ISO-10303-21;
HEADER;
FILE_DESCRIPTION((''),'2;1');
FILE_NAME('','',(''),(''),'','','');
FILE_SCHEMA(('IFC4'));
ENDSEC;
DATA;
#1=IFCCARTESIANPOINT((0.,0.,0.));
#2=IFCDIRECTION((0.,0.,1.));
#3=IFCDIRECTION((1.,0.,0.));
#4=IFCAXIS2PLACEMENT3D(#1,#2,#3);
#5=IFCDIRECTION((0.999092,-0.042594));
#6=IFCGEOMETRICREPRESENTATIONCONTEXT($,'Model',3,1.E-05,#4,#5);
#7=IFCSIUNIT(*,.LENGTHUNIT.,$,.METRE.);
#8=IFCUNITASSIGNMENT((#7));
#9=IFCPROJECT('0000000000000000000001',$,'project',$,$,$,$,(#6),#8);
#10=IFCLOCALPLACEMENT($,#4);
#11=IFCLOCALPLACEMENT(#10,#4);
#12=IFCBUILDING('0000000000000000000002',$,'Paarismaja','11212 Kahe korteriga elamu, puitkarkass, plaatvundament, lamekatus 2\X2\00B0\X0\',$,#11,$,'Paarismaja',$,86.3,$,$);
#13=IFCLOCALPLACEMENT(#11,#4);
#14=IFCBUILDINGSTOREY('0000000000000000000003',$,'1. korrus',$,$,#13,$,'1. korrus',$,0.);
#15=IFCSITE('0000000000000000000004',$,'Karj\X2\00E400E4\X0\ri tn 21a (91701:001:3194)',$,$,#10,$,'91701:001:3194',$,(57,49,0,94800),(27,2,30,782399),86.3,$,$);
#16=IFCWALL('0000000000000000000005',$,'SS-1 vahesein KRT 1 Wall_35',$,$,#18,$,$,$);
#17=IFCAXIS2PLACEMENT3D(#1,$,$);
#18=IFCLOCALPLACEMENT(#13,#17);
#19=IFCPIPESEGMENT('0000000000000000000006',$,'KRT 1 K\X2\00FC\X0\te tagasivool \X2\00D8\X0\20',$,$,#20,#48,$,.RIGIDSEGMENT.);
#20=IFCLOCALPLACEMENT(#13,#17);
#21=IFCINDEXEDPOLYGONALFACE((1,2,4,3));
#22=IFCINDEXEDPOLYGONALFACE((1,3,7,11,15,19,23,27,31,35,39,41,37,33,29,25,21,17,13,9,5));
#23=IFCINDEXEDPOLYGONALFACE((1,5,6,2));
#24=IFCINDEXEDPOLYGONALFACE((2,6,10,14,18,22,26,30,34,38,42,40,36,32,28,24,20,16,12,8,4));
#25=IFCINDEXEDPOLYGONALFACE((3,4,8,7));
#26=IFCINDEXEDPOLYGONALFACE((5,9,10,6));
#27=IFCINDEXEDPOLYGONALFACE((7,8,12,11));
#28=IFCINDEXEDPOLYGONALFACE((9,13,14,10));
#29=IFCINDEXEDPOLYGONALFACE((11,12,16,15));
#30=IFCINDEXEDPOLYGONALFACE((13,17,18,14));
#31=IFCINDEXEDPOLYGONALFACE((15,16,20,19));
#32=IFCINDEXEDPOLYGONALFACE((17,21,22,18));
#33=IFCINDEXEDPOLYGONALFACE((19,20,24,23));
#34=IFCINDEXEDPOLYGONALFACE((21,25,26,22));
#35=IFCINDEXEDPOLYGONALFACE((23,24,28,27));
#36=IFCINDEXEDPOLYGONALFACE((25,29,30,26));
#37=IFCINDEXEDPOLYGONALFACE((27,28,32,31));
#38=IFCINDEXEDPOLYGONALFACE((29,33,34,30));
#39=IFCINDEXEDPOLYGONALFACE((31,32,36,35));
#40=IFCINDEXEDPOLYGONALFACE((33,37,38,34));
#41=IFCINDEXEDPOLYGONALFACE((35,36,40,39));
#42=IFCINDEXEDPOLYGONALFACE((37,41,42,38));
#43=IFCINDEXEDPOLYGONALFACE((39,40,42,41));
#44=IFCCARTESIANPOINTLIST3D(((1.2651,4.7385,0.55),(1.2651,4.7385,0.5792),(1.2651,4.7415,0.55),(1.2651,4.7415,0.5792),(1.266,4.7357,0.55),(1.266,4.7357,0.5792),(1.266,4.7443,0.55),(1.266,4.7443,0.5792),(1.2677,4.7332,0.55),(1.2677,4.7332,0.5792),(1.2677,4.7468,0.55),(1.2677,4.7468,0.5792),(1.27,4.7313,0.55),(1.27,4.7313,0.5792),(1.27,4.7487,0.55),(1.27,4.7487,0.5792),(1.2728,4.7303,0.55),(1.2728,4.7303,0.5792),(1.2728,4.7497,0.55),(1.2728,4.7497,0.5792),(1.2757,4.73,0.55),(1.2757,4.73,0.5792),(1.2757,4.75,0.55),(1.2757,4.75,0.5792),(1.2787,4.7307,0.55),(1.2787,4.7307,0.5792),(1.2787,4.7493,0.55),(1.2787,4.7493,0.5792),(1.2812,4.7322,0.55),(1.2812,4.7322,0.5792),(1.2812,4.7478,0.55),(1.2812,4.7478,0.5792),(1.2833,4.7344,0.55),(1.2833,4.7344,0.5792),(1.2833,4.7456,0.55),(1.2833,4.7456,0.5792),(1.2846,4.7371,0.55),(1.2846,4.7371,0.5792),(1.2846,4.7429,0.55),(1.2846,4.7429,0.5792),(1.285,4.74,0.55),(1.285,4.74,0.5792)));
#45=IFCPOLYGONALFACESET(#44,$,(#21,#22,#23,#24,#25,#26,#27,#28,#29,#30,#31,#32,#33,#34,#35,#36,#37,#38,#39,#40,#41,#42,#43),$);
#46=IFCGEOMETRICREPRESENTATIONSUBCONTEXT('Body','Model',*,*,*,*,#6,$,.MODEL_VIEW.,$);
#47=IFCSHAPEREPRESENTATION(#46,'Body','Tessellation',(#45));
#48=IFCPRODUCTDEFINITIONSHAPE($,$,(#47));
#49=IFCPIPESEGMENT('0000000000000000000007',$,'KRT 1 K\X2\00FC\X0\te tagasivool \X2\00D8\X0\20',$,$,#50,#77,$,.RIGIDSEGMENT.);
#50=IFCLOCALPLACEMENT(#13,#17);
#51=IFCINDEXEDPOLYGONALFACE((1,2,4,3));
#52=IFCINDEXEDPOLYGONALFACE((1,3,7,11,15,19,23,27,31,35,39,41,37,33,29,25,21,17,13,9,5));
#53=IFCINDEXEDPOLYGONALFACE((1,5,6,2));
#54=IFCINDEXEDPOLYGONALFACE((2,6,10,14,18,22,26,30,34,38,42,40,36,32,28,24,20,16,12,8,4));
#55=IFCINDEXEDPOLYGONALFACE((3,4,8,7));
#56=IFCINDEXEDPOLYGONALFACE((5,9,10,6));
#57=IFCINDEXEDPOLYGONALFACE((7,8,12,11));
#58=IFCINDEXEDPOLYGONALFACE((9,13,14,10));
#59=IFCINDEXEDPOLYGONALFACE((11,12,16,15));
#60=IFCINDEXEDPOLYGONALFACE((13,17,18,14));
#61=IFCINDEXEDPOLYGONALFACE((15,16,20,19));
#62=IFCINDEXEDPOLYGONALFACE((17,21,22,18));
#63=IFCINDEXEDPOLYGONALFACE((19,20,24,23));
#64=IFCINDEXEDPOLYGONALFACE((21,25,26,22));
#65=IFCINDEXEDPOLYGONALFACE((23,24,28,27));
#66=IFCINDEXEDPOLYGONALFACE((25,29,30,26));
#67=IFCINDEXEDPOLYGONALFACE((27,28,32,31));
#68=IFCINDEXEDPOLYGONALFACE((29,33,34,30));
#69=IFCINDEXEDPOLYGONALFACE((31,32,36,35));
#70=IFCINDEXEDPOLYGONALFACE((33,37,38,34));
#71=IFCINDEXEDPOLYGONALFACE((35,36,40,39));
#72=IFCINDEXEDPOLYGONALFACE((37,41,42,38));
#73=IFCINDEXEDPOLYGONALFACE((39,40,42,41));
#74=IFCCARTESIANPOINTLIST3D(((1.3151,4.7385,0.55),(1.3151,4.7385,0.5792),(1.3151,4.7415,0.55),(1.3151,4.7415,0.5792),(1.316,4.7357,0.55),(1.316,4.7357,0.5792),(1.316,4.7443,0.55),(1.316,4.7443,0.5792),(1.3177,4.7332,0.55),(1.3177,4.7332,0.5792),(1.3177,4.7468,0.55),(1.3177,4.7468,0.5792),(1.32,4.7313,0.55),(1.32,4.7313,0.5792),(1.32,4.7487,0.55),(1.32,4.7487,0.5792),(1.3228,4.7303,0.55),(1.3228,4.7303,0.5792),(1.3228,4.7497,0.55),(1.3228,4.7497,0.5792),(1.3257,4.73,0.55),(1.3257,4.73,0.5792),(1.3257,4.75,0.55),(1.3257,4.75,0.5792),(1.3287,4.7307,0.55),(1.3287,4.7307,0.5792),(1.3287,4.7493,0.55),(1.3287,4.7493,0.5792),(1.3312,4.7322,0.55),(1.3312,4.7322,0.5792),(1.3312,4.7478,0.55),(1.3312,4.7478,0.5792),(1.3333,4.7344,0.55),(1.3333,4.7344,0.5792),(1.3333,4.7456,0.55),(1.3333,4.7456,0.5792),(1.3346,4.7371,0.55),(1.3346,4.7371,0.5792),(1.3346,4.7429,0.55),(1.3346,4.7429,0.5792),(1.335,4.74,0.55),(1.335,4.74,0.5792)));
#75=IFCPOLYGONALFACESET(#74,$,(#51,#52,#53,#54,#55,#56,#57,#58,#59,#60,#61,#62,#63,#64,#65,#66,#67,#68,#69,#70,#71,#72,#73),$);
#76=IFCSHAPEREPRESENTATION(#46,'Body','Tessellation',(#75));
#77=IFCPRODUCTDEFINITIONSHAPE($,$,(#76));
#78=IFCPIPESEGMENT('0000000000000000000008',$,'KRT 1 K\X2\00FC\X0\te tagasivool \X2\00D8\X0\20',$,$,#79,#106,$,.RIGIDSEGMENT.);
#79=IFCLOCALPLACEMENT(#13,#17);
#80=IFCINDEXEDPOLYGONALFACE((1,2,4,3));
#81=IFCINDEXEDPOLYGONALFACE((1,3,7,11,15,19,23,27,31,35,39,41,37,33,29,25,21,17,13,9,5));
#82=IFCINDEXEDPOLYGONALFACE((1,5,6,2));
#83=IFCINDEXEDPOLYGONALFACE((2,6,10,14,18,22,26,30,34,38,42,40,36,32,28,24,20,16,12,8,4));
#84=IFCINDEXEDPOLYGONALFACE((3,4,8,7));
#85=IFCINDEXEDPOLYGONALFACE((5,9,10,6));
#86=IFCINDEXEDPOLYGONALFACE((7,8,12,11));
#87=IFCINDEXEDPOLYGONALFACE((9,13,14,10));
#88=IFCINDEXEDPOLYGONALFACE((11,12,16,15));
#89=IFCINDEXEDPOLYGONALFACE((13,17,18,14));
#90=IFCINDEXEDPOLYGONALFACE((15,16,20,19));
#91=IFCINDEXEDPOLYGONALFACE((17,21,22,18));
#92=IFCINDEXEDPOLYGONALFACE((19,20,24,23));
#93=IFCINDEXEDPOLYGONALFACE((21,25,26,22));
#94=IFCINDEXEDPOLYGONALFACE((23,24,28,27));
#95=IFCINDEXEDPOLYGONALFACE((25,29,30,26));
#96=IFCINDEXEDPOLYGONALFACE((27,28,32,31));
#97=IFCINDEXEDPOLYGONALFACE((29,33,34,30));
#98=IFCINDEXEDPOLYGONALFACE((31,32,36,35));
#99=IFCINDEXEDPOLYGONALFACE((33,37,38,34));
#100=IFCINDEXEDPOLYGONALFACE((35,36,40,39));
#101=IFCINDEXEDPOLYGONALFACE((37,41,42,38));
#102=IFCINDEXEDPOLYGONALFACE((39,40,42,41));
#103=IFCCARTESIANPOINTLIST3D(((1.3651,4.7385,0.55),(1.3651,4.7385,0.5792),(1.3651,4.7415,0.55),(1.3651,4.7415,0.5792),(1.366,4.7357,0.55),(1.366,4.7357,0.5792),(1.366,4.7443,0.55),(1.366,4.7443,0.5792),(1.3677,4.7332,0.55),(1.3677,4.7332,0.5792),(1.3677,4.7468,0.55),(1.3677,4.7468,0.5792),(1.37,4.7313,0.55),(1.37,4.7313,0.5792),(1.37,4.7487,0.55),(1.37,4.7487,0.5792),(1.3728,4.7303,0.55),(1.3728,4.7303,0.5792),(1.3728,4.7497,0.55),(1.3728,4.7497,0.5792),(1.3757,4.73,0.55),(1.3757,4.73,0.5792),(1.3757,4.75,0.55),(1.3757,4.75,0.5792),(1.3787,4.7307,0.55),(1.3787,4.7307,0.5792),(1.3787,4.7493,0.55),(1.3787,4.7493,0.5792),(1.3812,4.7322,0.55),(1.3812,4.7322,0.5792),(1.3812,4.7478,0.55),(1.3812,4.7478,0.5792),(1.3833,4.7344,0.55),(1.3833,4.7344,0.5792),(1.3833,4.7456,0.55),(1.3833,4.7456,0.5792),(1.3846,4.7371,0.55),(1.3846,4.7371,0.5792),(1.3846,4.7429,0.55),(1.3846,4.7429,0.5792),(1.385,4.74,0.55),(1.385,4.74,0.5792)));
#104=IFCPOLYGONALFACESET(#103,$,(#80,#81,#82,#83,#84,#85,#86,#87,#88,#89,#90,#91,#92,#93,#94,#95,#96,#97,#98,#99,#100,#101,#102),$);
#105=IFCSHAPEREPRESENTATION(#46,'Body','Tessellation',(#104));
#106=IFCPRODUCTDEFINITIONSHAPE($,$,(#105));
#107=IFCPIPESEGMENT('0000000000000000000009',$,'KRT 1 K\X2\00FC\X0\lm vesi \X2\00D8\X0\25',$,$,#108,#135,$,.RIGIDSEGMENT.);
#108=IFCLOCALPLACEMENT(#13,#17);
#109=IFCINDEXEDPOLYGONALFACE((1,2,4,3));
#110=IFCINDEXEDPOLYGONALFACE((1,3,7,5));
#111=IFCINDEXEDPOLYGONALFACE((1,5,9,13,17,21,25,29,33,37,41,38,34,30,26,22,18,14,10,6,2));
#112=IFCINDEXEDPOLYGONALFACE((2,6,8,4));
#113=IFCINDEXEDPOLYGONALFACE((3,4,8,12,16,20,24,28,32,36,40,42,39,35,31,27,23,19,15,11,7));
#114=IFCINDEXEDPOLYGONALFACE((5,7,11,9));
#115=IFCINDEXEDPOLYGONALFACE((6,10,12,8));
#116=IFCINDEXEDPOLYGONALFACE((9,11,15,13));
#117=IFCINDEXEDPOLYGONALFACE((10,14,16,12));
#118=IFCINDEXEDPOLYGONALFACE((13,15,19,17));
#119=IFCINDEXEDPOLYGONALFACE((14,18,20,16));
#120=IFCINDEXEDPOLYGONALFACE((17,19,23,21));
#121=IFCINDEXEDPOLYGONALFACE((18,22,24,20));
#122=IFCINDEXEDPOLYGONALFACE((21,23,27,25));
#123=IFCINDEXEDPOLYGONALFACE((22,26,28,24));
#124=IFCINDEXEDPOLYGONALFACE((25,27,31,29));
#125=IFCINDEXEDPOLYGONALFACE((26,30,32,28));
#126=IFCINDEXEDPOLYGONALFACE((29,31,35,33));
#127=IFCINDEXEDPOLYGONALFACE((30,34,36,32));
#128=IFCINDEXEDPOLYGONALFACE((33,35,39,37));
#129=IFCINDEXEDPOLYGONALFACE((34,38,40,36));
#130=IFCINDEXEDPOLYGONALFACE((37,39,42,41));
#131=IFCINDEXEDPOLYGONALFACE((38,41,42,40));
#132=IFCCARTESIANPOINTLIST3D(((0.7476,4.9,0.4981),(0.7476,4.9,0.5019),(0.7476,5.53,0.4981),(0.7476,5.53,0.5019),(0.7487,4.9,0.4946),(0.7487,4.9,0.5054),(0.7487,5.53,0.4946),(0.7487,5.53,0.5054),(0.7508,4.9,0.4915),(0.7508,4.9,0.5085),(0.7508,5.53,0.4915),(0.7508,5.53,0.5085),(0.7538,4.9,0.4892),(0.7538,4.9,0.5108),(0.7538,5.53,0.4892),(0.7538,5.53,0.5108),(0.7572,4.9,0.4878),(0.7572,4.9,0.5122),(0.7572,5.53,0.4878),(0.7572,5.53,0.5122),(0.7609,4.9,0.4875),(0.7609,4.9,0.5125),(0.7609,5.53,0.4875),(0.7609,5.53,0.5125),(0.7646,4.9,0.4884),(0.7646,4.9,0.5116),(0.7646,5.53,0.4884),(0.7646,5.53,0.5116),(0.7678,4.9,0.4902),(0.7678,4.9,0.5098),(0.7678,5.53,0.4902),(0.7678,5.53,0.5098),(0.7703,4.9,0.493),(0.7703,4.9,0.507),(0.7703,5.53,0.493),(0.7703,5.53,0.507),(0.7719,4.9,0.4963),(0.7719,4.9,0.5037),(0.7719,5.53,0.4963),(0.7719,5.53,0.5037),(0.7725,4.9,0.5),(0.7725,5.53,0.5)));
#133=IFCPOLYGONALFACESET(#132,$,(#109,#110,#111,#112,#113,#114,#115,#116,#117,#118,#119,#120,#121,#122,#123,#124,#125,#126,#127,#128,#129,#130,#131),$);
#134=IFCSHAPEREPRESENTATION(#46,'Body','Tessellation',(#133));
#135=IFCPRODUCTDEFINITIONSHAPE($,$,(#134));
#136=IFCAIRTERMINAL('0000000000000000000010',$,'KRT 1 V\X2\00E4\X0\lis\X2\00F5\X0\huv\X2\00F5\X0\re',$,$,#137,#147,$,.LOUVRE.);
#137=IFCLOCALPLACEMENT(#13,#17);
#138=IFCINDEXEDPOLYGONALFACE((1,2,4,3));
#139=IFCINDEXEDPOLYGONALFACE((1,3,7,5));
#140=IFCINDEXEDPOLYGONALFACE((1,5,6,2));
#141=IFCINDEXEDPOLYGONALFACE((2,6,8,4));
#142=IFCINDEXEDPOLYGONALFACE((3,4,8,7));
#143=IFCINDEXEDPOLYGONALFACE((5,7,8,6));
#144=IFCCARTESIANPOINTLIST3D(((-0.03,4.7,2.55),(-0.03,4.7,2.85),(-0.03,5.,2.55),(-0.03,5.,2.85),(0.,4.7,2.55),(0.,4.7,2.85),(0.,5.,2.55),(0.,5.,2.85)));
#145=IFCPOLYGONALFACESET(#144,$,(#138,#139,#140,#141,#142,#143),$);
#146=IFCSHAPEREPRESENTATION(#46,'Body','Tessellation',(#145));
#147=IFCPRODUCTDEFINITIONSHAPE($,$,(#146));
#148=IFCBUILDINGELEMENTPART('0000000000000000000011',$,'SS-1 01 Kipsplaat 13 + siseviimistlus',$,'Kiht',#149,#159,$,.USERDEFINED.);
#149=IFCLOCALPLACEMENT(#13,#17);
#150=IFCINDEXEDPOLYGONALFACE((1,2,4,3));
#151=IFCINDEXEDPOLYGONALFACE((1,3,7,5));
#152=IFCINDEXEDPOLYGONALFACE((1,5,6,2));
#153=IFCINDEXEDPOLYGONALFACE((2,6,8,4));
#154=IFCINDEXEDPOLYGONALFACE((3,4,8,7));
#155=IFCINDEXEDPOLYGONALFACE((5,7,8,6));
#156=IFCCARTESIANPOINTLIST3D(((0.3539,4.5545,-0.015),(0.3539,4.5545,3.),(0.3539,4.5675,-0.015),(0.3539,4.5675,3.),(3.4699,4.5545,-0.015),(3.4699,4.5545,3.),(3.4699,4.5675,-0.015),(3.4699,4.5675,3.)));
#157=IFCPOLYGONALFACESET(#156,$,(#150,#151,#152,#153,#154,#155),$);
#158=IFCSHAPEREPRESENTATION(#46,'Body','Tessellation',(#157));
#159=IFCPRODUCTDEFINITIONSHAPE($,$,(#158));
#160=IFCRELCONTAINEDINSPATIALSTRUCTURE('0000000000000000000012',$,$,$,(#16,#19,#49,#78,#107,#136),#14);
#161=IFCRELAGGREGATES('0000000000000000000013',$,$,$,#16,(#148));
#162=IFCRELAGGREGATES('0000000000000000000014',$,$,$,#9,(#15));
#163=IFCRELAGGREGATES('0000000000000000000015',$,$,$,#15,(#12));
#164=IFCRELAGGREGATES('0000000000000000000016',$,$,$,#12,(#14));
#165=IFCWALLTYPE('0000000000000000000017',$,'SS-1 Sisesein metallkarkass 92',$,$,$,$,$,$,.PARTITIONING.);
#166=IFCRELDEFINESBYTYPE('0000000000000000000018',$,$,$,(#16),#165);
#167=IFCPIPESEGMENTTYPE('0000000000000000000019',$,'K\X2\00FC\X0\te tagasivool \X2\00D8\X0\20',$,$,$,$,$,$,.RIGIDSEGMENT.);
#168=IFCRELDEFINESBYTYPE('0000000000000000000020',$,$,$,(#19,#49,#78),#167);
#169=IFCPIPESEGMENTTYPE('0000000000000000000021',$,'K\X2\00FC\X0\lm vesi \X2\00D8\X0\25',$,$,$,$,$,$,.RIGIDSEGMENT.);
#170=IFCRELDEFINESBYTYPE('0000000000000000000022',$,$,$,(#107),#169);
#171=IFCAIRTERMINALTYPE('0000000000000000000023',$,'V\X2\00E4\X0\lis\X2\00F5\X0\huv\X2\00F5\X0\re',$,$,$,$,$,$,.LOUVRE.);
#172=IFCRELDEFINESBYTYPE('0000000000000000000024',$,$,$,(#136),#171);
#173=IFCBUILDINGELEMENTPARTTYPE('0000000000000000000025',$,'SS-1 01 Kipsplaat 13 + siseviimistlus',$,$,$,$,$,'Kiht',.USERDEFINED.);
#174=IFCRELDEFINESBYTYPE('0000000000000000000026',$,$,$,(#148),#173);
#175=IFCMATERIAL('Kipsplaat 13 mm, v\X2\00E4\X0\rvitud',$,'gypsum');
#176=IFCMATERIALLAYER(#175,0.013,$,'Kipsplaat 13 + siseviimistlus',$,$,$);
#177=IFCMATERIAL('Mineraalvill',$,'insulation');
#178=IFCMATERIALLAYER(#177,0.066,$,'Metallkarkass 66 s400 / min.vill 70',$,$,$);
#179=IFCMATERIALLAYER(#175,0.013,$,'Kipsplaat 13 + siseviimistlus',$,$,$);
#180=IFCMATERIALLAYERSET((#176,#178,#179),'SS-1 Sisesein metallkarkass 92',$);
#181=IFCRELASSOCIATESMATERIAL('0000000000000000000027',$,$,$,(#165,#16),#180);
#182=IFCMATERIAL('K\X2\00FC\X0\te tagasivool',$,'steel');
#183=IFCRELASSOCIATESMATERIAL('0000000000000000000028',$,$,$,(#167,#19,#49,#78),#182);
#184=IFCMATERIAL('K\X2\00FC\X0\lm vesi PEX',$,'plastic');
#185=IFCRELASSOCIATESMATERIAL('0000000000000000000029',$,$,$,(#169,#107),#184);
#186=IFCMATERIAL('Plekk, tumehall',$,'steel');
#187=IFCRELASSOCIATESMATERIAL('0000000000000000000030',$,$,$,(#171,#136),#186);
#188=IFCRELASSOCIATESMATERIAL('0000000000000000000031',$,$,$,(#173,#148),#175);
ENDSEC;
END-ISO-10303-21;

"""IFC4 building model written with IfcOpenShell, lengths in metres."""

from ifc_helpers import new_model, si_unit, direction, frame, origin_with_axes, place, context, subcontext, project, spatial, indexed_curve, circle, outline, extrude, material, layer, layer_set, layer_usage, type_object, element, aggregate, save


model = new_model("IFC4")

# Units and contexts
model_context = context("Model", 3, precision=1e-05, world=origin_with_axes(), true_north=direction((0.999092, -0.042594)))
body_context = subcontext(model_context, "Body", "Model", "MODEL_VIEW")
ifc_project = project(units=[si_unit("LENGTHUNIT", "METRE")], contexts=[model_context])

# Site, building, storey
site_placement = place(None, origin_with_axes())
site = spatial("IfcSite", under=ifc_project, at=site_placement, Name="Karjääri tn 21a (91701:001:3194)", LongName="91701:001:3194", RefLatitude=(57, 49, 0, 94800), RefLongitude=(27, 2, 30, 782399), RefElevation=86.3)
building_placement = place(site_placement, origin_with_axes())
building = spatial("IfcBuilding", under=site, at=building_placement, Name="Paarismaja", Description="11212 Kahe korteriga elamu, puitkarkass, plaatvundament, lamekatus 2°", LongName="Paarismaja", ElevationOfRefHeight=86.3)
storey_placement = place(building_placement, origin_with_axes())
storey = spatial("IfcBuildingStorey", under=building, at=storey_placement, Name="1. korrus", LongName="1. korrus", Elevation=0.0)

# Wall
ifc_material_1 = material(Name="Kipsplaat 13 mm, värvitud", Category="gypsum")
ifc_layer_1 = layer(ifc_material_1, 0.013, Name="Kipsplaat 13 + siseviimistlus")
ifc_material_2 = material(Name="Mineraalvill", Category="insulation")
ifc_layer_2 = layer(ifc_material_2, 0.066, Name="Metallkarkass 66 s400 / min.vill 70")
ifc_layer_3 = layer(ifc_material_1, 0.013, Name="Kipsplaat 13 + siseviimistlus")
ifc_layer_set = layer_set([ifc_layer_1, ifc_layer_2, ifc_layer_3], Name="SS-1 Sisesein metallkarkass 92")
ifc_layer_usage = layer_usage(ifc_layer_set, "AXIS2", "POSITIVE", 0.0)
wall_type = type_object("IfcWallType", Name="SS-1 Sisesein metallkarkass 92", PredefinedType="PARTITIONING", material=ifc_layer_set)
wall_placement = place(storey_placement, frame((0.3539, 4.5545, 0.0), z_axis=(0.0, 0.0, 1.0), x_axis=(1.0, 0.0, 0.0)))
wall = element("IfcWall", 1, at=wall_placement, inside=storey, type_object=wall_type, material=ifc_layer_usage, Name="SS-1 vahesein KRT 1 Wall_35")

# Shared definitions
ifc_material_3 = material(Name="Küte tagasivool", Category="steel")
ifc_material_4 = material(Name="Külm vesi PEX", Category="plastic")

# Pipe segments
pipe_segment_type_1 = type_object("IfcPipeSegmentType", Name="Küte tagasivool Ø20", PredefinedType="RIGIDSEGMENT", material=ifc_material_3)
for number, where, z_axis, x_axis, name in (
    (2, (1.275, 4.74, 0.55), (0.0, 0.0, 1.0), (1.0, 0.0, 0.0), "KRT 1 Küte tagasivool Ø20"),
    (3, (1.325, 4.74, 0.55), (0.0, 0.0, 1.0), (1.0, 0.0, 0.0), "KRT 1 Küte tagasivool Ø20"),
    (4, (1.375, 4.74, 0.55), (0.0, 0.0, 1.0), (1.0, 0.0, 0.0), "KRT 1 Küte tagasivool Ø20"),
):
    element("IfcPipeSegment", number, at=place(storey_placement, frame(where, z_axis=z_axis, x_axis=x_axis)), inside=storey, type_object=pipe_segment_type_1, material=ifc_material_3, Name=name, PredefinedType="RIGIDSEGMENT", context=body_context, shape_type="SweptSolid", body=[
        extrude(circle(Radius=0.01), origin_with_axes(), (0.0, 0.0, 1.0), 0.0292),
    ])
pipe_segment_type_2 = type_object("IfcPipeSegmentType", Name="Külm vesi Ø25", PredefinedType="RIGIDSEGMENT", material=ifc_material_4)
pipe_segment_1_placement = place(storey_placement, frame((0.76, 4.9, 0.5), z_axis=(0.0, 1.0, 0.0), x_axis=(1.0, 0.0, 0.0)))
element("IfcPipeSegment", 5, at=pipe_segment_1_placement, inside=storey, type_object=pipe_segment_type_2, material=ifc_material_4, Name="KRT 1 Külm vesi Ø25", PredefinedType="RIGIDSEGMENT", context=body_context, shape_type="SweptSolid", body=[
    extrude(circle(Radius=0.0125), origin_with_axes(), (0.0, 0.0, 1.0), 0.63),
])

# Air terminal
ifc_material_5 = material(Name="Plekk, tumehall", Category="steel")
air_terminal_type = type_object("IfcAirTerminalType", Name="Välisõhuvõre", PredefinedType="LOUVRE", material=ifc_material_5)
air_terminal_placement = place(storey_placement, frame((0.0, 4.85, 0.0), z_axis=(0.0, 0.0, 1.0), x_axis=(0.0, 1.0, 0.0)))
element("IfcAirTerminal", 6, at=air_terminal_placement, inside=storey, type_object=air_terminal_type, material=ifc_material_5, Name="KRT 1 Välisõhuvõre", PredefinedType="LOUVRE", context=body_context, shape_type="SweptSolid", body=[
    extrude(outline(indexed_curve([(-0.15, 0.0), (0.15, 0.0), (0.15, 0.03), (-0.15, 0.03), (-0.15, 0.0)], self_intersect=False)), frame((0.0, 0.0, 2.55), z_axis=(0.0, 0.0, 1.0), x_axis=(1.0, 0.0, 0.0)), (0.0, 0.0, 1.0), 0.3),
])

# Building element part
building_element_part_type_1 = type_object("IfcBuildingElementPartType", Name="SS-1 01 Kipsplaat 13 + siseviimistlus", ElementType="Kiht", PredefinedType="USERDEFINED", material=ifc_material_1)
building_element_part_1_placement = place(wall_placement, origin_with_axes())
building_element_part_1 = element("IfcBuildingElementPart", 7, at=building_element_part_1_placement, type_object=building_element_part_type_1, material=ifc_material_1, Name="SS-1 01 Kipsplaat 13 + siseviimistlus", ObjectType="Kiht", PredefinedType="USERDEFINED", context=body_context, shape_type="SweptSolid", body=[
    extrude(outline(indexed_curve([(3.116, -0.015), (3.116, 3.0), (0.0, 3.0), (0.0, -0.015), (3.116, -0.015)], self_intersect=False)), frame((0.0, 0.013, 0.0), z_axis=(0.0, -1.0, 0.0), x_axis=(1.0, 0.0, 0.0)), (0.0, 0.0, 1.0), 0.013),
])
aggregate(wall, [building_element_part_1])

save(model, "model.ifc")
